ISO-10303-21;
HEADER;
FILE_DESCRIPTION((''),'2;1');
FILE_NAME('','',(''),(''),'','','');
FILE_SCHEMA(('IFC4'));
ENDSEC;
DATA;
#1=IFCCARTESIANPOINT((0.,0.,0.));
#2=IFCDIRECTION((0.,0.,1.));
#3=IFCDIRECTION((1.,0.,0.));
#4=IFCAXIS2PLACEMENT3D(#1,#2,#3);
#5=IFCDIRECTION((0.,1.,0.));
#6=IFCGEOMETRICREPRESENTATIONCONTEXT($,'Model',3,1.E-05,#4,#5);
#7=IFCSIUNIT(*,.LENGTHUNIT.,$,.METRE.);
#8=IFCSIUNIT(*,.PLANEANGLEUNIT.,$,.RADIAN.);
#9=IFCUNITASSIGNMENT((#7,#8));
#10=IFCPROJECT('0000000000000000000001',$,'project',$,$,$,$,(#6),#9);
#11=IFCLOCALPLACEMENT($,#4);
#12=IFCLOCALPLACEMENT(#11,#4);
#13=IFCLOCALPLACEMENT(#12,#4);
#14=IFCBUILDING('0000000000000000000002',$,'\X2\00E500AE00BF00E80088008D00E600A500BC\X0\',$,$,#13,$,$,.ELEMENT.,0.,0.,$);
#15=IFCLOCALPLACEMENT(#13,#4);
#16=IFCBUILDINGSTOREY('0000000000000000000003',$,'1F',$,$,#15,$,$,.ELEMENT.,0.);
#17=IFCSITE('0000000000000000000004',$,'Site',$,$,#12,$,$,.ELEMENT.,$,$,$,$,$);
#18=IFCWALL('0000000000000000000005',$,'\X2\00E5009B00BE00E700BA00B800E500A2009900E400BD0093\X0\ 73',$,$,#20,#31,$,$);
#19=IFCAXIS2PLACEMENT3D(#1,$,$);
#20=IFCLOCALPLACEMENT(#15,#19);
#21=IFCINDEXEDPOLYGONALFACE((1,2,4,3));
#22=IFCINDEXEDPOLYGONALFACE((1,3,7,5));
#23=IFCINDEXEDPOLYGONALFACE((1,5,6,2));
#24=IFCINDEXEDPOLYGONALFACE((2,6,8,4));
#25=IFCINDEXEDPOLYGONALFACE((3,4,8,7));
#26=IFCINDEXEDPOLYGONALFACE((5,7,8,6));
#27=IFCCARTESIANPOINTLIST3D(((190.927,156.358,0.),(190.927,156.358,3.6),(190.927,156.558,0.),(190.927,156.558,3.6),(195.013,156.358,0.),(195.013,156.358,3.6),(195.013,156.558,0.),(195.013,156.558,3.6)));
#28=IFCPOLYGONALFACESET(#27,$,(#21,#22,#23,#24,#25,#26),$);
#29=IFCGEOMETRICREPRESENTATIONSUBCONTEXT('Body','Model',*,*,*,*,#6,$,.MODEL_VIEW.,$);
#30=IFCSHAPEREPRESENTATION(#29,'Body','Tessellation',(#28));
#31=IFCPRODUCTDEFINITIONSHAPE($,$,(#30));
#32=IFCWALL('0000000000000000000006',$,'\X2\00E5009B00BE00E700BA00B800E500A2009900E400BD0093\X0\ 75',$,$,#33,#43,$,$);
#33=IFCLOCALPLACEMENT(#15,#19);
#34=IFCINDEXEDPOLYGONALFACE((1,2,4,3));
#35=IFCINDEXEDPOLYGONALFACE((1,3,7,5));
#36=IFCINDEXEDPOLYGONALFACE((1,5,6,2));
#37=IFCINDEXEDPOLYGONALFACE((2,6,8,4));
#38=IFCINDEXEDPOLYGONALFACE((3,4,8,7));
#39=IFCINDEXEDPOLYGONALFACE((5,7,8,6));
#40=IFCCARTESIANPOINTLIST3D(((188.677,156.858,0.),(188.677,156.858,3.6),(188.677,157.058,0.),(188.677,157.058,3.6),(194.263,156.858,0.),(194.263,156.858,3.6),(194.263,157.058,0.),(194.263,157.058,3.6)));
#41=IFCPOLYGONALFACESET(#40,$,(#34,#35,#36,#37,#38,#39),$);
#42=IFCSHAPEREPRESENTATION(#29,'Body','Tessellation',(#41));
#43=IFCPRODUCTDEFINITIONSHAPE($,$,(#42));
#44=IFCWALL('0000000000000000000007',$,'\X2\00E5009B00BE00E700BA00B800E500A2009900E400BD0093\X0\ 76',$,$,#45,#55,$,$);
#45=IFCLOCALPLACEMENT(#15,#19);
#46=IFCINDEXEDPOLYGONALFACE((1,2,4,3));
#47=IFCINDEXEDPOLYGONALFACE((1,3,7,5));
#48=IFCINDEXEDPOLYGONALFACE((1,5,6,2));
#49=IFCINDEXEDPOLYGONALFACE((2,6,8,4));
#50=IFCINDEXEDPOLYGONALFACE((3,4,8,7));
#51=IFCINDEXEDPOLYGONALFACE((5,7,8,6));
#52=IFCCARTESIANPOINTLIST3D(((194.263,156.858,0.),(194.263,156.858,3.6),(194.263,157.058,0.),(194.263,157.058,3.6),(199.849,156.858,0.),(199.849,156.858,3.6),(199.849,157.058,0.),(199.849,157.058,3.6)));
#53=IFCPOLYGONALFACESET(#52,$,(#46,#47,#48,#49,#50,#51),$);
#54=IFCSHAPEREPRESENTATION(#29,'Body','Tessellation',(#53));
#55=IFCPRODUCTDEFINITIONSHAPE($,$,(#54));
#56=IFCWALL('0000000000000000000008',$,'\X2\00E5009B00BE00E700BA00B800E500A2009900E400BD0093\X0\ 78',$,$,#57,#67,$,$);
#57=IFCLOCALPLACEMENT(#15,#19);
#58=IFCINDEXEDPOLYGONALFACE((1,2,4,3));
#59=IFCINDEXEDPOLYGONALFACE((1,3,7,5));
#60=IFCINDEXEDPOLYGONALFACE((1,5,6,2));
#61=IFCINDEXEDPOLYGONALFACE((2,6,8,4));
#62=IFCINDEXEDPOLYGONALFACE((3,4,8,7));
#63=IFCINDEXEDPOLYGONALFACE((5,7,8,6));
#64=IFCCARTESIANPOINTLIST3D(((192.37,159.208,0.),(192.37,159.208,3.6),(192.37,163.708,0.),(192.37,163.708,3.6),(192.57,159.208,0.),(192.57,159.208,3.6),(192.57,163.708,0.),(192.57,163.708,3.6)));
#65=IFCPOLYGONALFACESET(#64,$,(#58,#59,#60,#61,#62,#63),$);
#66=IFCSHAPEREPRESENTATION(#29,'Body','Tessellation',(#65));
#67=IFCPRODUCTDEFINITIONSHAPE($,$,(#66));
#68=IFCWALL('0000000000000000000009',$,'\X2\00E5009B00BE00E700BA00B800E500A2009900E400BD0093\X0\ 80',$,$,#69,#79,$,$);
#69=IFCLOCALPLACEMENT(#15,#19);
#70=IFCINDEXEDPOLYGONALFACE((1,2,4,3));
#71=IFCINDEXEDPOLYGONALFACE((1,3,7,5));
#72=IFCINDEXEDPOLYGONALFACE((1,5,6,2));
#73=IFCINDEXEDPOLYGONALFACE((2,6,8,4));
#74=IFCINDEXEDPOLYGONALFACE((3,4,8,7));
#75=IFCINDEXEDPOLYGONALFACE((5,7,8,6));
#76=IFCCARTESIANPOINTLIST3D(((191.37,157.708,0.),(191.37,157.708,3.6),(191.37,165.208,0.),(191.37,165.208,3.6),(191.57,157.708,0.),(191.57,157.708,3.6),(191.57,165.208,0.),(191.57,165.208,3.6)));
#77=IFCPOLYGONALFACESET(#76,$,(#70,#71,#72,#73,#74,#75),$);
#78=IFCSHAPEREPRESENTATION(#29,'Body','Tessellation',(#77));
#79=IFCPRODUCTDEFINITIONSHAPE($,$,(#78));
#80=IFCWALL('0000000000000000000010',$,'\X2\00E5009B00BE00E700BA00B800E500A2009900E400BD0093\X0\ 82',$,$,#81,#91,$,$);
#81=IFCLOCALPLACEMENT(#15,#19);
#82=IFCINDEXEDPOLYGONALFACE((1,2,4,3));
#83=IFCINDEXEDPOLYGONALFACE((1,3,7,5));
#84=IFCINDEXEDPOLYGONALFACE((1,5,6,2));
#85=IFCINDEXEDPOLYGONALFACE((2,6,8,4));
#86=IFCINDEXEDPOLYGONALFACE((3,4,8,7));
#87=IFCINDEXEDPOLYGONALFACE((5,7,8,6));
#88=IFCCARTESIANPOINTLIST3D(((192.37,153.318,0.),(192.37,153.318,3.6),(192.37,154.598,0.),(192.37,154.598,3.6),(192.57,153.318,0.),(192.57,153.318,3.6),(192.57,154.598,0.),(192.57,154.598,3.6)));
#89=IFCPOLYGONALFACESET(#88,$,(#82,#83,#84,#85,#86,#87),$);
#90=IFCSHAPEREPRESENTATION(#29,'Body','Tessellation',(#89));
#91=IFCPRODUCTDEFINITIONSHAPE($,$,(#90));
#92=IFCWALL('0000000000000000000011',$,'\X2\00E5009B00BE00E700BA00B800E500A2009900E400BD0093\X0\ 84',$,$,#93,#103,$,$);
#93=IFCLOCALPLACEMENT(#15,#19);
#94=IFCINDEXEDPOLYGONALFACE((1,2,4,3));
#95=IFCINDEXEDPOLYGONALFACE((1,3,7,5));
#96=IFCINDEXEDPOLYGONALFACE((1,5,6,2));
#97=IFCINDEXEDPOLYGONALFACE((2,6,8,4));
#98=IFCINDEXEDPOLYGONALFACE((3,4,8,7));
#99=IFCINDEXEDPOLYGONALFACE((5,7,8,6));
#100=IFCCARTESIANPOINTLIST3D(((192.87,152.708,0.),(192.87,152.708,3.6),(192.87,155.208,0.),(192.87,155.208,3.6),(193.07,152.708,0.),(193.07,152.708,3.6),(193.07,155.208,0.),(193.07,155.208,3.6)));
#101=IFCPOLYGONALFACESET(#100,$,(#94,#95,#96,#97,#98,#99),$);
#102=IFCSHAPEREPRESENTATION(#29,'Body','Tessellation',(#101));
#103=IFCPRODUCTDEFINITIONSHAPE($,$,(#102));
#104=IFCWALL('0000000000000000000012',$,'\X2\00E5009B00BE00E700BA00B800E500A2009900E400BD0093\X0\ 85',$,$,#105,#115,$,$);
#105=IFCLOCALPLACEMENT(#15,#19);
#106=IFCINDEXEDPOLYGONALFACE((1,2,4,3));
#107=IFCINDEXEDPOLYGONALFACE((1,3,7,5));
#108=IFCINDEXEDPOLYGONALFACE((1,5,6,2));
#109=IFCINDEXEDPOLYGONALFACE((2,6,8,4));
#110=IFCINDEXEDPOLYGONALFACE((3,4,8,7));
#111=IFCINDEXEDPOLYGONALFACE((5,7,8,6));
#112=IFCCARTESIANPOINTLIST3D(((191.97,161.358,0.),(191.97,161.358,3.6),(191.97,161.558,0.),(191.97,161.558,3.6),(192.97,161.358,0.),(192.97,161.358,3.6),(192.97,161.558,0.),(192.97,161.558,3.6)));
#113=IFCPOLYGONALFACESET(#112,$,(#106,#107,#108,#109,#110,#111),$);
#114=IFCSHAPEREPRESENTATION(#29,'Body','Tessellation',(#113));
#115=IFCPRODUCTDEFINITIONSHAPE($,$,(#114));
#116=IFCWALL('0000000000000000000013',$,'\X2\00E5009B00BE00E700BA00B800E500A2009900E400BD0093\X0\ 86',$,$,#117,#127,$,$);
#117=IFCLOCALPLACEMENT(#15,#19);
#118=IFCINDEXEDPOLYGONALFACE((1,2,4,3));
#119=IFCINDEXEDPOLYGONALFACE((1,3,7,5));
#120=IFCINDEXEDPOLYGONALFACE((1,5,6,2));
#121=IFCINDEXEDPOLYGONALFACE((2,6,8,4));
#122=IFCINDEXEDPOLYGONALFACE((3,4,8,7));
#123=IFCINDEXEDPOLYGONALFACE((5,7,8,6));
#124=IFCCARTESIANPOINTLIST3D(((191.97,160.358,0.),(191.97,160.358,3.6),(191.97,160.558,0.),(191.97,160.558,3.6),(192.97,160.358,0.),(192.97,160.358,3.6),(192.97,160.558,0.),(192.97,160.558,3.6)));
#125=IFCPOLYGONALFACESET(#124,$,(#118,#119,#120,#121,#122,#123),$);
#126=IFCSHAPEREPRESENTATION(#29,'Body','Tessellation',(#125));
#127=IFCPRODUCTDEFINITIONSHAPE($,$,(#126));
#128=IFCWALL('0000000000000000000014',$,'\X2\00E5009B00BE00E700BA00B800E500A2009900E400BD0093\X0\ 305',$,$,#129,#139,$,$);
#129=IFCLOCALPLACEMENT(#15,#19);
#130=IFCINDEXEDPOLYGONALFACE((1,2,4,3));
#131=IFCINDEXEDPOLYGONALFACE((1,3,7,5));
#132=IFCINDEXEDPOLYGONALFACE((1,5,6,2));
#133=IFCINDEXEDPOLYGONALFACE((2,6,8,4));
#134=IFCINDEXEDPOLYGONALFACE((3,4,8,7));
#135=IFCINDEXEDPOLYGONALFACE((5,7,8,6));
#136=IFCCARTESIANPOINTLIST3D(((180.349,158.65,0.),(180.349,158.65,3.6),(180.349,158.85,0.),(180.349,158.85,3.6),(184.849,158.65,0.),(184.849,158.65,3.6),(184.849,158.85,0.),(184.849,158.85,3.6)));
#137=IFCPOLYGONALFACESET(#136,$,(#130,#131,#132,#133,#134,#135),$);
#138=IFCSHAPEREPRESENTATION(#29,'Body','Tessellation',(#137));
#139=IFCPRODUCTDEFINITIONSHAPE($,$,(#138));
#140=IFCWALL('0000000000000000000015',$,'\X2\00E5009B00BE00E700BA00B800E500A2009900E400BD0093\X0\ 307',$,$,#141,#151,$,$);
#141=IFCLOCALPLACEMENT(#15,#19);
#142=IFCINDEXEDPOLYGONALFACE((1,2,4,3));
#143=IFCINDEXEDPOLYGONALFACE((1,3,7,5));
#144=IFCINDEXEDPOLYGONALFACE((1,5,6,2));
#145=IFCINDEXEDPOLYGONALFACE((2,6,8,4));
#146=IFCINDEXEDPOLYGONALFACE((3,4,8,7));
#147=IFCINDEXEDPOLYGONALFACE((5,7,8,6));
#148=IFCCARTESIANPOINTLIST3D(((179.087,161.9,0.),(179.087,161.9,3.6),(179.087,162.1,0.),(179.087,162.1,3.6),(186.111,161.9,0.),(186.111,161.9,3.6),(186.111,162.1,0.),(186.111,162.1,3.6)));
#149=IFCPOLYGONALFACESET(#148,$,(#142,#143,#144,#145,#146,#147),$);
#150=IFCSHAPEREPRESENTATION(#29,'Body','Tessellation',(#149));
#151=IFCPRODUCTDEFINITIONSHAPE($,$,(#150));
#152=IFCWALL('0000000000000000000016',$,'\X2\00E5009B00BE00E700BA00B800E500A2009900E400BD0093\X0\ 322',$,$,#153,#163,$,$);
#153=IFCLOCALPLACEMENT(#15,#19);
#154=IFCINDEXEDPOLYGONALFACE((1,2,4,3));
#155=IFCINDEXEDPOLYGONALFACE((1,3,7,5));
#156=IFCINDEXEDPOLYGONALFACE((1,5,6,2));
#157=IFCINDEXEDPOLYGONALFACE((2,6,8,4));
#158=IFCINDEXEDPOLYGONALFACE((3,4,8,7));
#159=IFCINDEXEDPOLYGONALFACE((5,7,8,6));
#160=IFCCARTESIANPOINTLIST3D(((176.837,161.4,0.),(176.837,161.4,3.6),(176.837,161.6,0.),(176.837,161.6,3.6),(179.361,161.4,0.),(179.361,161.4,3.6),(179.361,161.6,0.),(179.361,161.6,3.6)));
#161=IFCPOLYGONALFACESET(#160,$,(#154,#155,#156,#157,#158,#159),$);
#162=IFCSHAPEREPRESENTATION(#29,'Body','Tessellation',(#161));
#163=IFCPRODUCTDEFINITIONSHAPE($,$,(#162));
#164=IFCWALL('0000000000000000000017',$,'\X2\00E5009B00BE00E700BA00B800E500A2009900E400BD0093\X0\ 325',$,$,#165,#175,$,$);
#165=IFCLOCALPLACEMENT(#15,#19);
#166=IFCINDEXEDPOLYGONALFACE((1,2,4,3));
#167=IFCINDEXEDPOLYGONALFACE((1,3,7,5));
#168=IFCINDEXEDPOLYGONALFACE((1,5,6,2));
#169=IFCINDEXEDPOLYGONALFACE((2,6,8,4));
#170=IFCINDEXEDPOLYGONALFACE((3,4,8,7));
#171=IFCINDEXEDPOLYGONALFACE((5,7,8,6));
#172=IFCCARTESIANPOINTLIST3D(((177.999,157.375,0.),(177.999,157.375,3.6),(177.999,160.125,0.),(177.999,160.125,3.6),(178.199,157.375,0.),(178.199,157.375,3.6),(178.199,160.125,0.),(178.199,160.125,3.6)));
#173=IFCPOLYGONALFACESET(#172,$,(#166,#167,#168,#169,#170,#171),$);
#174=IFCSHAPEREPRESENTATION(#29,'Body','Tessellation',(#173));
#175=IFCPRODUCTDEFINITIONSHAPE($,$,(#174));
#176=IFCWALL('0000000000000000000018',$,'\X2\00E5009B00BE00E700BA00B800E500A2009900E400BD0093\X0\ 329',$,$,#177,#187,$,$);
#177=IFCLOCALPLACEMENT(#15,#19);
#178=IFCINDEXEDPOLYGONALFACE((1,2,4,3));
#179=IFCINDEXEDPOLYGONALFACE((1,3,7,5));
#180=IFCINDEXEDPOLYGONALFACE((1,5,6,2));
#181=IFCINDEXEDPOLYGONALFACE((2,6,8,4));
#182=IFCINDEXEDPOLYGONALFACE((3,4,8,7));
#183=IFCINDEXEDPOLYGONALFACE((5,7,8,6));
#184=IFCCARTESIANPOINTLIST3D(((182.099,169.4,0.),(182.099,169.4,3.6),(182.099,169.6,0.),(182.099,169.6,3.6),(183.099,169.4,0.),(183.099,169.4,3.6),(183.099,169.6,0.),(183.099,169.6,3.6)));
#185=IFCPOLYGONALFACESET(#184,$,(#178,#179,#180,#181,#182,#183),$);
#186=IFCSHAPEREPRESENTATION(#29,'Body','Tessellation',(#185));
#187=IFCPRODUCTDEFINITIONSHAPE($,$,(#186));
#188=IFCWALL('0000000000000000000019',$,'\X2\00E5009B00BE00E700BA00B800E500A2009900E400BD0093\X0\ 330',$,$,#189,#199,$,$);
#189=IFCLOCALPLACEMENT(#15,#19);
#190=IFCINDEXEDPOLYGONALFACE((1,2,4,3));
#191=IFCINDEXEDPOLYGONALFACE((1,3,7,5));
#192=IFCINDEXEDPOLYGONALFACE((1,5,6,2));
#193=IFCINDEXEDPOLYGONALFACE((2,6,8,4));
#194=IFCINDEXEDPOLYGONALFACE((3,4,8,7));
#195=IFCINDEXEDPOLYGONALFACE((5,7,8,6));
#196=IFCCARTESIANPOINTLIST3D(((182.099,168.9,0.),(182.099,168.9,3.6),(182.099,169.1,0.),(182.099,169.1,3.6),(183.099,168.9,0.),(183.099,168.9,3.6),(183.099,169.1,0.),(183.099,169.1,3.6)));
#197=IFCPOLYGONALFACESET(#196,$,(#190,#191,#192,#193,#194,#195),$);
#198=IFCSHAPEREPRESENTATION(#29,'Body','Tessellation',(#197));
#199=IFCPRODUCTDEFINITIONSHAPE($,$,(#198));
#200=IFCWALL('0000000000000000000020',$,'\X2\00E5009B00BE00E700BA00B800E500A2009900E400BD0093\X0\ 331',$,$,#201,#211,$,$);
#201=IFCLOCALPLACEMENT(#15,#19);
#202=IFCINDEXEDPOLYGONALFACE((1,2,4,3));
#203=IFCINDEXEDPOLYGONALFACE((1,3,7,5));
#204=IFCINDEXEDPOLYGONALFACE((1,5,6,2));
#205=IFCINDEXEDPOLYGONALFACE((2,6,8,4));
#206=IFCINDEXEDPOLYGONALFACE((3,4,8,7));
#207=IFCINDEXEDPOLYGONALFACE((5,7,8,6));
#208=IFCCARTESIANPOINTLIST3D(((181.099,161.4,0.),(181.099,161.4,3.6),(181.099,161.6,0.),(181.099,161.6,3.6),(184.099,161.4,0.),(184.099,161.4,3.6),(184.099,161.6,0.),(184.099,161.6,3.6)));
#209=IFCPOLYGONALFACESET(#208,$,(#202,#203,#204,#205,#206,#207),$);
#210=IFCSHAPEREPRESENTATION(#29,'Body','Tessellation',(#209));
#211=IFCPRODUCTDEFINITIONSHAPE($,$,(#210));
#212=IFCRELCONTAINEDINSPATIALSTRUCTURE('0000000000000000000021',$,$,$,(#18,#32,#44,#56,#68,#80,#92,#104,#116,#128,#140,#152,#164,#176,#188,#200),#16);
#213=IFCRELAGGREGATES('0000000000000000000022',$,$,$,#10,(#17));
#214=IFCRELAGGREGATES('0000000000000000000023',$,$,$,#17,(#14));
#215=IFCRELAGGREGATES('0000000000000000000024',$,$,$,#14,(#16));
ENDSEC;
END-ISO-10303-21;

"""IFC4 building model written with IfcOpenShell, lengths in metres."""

from ifc_helpers import new_model, si_unit, direction, frame, frame_2d, origin_with_axes, place, context, subcontext, project, spatial, rectangle, extrude, element, save


model = new_model("IFC4")

# Units and contexts
model_context = context("Model", 3, precision=1e-05, world=origin_with_axes(), true_north=direction((0.0, 1.0, 0.0)))
body_context = subcontext(model_context, "Body", "Model", "MODEL_VIEW")
ifc_project = project(units=[si_unit("LENGTHUNIT", "METRE"), si_unit("PLANEANGLEUNIT", "RADIAN")], contexts=[model_context])

# Site, building, storey
placement = place(None, origin_with_axes())
site_placement = place(placement, origin_with_axes())
site = spatial("IfcSite", under=ifc_project, at=site_placement, Name="Site", CompositionType="ELEMENT")
building_placement = place(site_placement, origin_with_axes())
building = spatial("IfcBuilding", under=site, at=building_placement, Name="å®¿è\u0088\u008dæ¥¼", CompositionType="ELEMENT", ElevationOfRefHeight=0.0, ElevationOfTerrain=0.0)
storey_placement = place(building_placement, origin_with_axes())
storey = spatial("IfcBuildingStorey", under=building, at=storey_placement, Name="1F", CompositionType="ELEMENT", Elevation=0.0)

# Walls
for number, where, z_axis, x_axis, name in (
    (1, (192.97, 156.458, 0.0), (0.0, 0.0, 1.0), (1.0, 0.0, 0.0), "å\u009b¾çº¸å¢\u0099ä½\u0093 73"),
):
    element("IfcWall", number, at=place(storey_placement, frame(where, z_axis=z_axis, x_axis=x_axis)), inside=storey, Name=name, context=body_context, shape_type="SweptSolid", body=[
        extrude(rectangle(XDim=4.086, YDim=0.2, at=frame_2d((0.0, 0.0), x_axis=(1.0, 0.0, 0.0))), frame((0.0, 0.0, 0.0), z_axis=(0.0, 0.0, 1.0)), (0.0, 0.0, 1.0), 3.6),
    ])
for number, where, z_axis, x_axis, name in (
    (2, (191.47, 156.958, 0.0), (0.0, 0.0, 1.0), (1.0, 0.0, 0.0), "å\u009b¾çº¸å¢\u0099ä½\u0093 75"),
    (3, (197.056, 156.958, 0.0), (0.0, 0.0, 1.0), (-1.0, 0.0, 0.0), "å\u009b¾çº¸å¢\u0099ä½\u0093 76"),
):
    element("IfcWall", number, at=place(storey_placement, frame(where, z_axis=z_axis, x_axis=x_axis)), inside=storey, Name=name, context=body_context, shape_type="SweptSolid", body=[
        extrude(rectangle(XDim=5.586, YDim=0.2, at=frame_2d((0.0, 0.0), x_axis=(1.0, 0.0, 0.0))), frame((0.0, 0.0, 0.0), z_axis=(0.0, 0.0, 1.0)), (0.0, 0.0, 1.0), 3.6),
    ])
wall_1_placement = place(storey_placement, frame((192.47, 161.458, 0.0), z_axis=(0.0, 0.0, 1.0), x_axis=(0.0, -1.0, 0.0)))
element("IfcWall", 4, at=wall_1_placement, inside=storey, Name="å\u009b¾çº¸å¢\u0099ä½\u0093 78", context=body_context, shape_type="SweptSolid", body=[
    extrude(rectangle(XDim=4.5, YDim=0.2, at=frame_2d((0.0, 0.0), x_axis=(1.0, 0.0, 0.0))), frame((0.0, 0.0, 0.0), z_axis=(0.0, 0.0, 1.0)), (0.0, 0.0, 1.0), 3.6),
])
wall_2_placement = place(storey_placement, frame((191.47, 161.458, 0.0), z_axis=(0.0, 0.0, 1.0), x_axis=(0.0, -1.0, 0.0)))
element("IfcWall", 5, at=wall_2_placement, inside=storey, Name="å\u009b¾çº¸å¢\u0099ä½\u0093 80", context=body_context, shape_type="SweptSolid", body=[
    extrude(rectangle(XDim=7.5, YDim=0.2, at=frame_2d((0.0, 0.0), x_axis=(1.0, 0.0, 0.0))), frame((0.0, 0.0, 0.0), z_axis=(0.0, 0.0, 1.0)), (0.0, 0.0, 1.0), 3.6),
])
wall_3_placement = place(storey_placement, frame((192.47, 153.958, 0.0), z_axis=(0.0, 0.0, 1.0), x_axis=(0.0, -1.0, 0.0)))
element("IfcWall", 6, at=wall_3_placement, inside=storey, Name="å\u009b¾çº¸å¢\u0099ä½\u0093 82", context=body_context, shape_type="SweptSolid", body=[
    extrude(rectangle(XDim=1.28, YDim=0.2, at=frame_2d((0.0, 0.0), x_axis=(1.0, 0.0, 0.0))), frame((0.0, 0.0, 0.0), z_axis=(0.0, 0.0, 1.0)), (0.0, 0.0, 1.0), 3.6),
])
wall_4_placement = place(storey_placement, frame((192.97, 153.958, 0.0), z_axis=(0.0, 0.0, 1.0), x_axis=(0.0, 1.0, 0.0)))
element("IfcWall", 7, at=wall_4_placement, inside=storey, Name="å\u009b¾çº¸å¢\u0099ä½\u0093 84", context=body_context, shape_type="SweptSolid", body=[
    extrude(rectangle(XDim=2.5, YDim=0.2, at=frame_2d((0.0, 0.0), x_axis=(1.0, 0.0, 0.0))), frame((0.0, 0.0, 0.0), z_axis=(0.0, 0.0, 1.0)), (0.0, 0.0, 1.0), 3.6),
])
for number, where, z_axis, x_axis, name in (
    (8, (192.47, 161.458, 0.0), (0.0, 0.0, 1.0), (-1.0, 0.0, 0.0), "å\u009b¾çº¸å¢\u0099ä½\u0093 85"),
    (9, (192.47, 160.458, 0.0), (0.0, 0.0, 1.0), (-1.0, 0.0, 0.0), "å\u009b¾çº¸å¢\u0099ä½\u0093 86"),
):
    element("IfcWall", number, at=place(storey_placement, frame(where, z_axis=z_axis, x_axis=x_axis)), inside=storey, Name=name, context=body_context, shape_type="SweptSolid", body=[
        extrude(rectangle(XDim=1.0, YDim=0.2, at=frame_2d((0.0, 0.0), x_axis=(1.0, 0.0, 0.0))), frame((0.0, 0.0, 0.0), z_axis=(0.0, 0.0, 1.0)), (0.0, 0.0, 1.0), 3.6),
    ])
wall_5_placement = place(storey_placement, frame((182.599, 158.75, 0.0), z_axis=(0.0, 0.0, 1.0), x_axis=(-1.0, 0.0, 0.0)))
element("IfcWall", 10, at=wall_5_placement, inside=storey, Name="å\u009b¾çº¸å¢\u0099ä½\u0093 305", context=body_context, shape_type="SweptSolid", body=[
    extrude(rectangle(XDim=4.5, YDim=0.2, at=frame_2d((0.0, 0.0), x_axis=(1.0, 0.0, 0.0))), frame((0.0, 0.0, 0.0), z_axis=(0.0, 0.0, 1.0)), (0.0, 0.0, 1.0), 3.6),
])
wall_6_placement = place(storey_placement, frame((182.599, 162.0, 0.0), z_axis=(0.0, 0.0, 1.0), x_axis=(-1.0, 0.0, 0.0)))
element("IfcWall", 11, at=wall_6_placement, inside=storey, Name="å\u009b¾çº¸å¢\u0099ä½\u0093 307", context=body_context, shape_type="SweptSolid", body=[
    extrude(rectangle(XDim=7.024, YDim=0.2, at=frame_2d((0.0, 0.0), x_axis=(1.0, 0.0, 0.0))), frame((0.0, 0.0, 0.0), z_axis=(0.0, 0.0, 1.0)), (0.0, 0.0, 1.0), 3.6),
])
wall_7_placement = place(storey_placement, frame((178.099, 161.5, 0.0), z_axis=(0.0, 0.0, 1.0), x_axis=(-1.0, 0.0, 0.0)))
element("IfcWall", 12, at=wall_7_placement, inside=storey, Name="å\u009b¾çº¸å¢\u0099ä½\u0093 322", context=body_context, shape_type="SweptSolid", body=[
    extrude(rectangle(XDim=2.524, YDim=0.2, at=frame_2d((0.0, 0.0), x_axis=(1.0, 0.0, 0.0))), frame((0.0, 0.0, 0.0), z_axis=(0.0, 0.0, 1.0)), (0.0, 0.0, 1.0), 3.6),
])
wall_8_placement = place(storey_placement, frame((178.099, 158.75, 0.0), z_axis=(0.0, 0.0, 1.0), x_axis=(0.0, 1.0, 0.0)))
element("IfcWall", 13, at=wall_8_placement, inside=storey, Name="å\u009b¾çº¸å¢\u0099ä½\u0093 325", context=body_context, shape_type="SweptSolid", body=[
    extrude(rectangle(XDim=2.75, YDim=0.2, at=frame_2d((0.0, 0.0), x_axis=(1.0, 0.0, 0.0))), frame((0.0, 0.0, 0.0), z_axis=(0.0, 0.0, 1.0)), (0.0, 0.0, 1.0), 3.6),
])
for number, where, z_axis, x_axis, name in (
    (14, (182.599, 169.5, 0.0), (0.0, 0.0, 1.0), (-1.0, 0.0, 0.0), "å\u009b¾çº¸å¢\u0099ä½\u0093 329"),
    (15, (182.599, 169.0, 0.0), (0.0, 0.0, 1.0), (-1.0, 0.0, 0.0), "å\u009b¾çº¸å¢\u0099ä½\u0093 330"),
):
    element("IfcWall", number, at=place(storey_placement, frame(where, z_axis=z_axis, x_axis=x_axis)), inside=storey, Name=name, context=body_context, shape_type="SweptSolid", body=[
        extrude(rectangle(XDim=1.0, YDim=0.2, at=frame_2d((0.0, 0.0), x_axis=(1.0, 0.0, 0.0))), frame((0.0, 0.0, 0.0), z_axis=(0.0, 0.0, 1.0)), (0.0, 0.0, 1.0), 3.6),
    ])
wall_9_placement = place(storey_placement, frame((182.599, 161.5, 0.0), z_axis=(0.0, 0.0, 1.0), x_axis=(-1.0, 0.0, 0.0)))
element("IfcWall", 16, at=wall_9_placement, inside=storey, Name="å\u009b¾çº¸å¢\u0099ä½\u0093 331", context=body_context, shape_type="SweptSolid", body=[
    extrude(rectangle(XDim=3.0, YDim=0.2, at=frame_2d((0.0, 0.0), x_axis=(1.0, 0.0, 0.0))), frame((0.0, 0.0, 0.0), z_axis=(0.0, 0.0, 1.0)), (0.0, 0.0, 1.0), 3.6),
])

save(model, "model.ifc")
